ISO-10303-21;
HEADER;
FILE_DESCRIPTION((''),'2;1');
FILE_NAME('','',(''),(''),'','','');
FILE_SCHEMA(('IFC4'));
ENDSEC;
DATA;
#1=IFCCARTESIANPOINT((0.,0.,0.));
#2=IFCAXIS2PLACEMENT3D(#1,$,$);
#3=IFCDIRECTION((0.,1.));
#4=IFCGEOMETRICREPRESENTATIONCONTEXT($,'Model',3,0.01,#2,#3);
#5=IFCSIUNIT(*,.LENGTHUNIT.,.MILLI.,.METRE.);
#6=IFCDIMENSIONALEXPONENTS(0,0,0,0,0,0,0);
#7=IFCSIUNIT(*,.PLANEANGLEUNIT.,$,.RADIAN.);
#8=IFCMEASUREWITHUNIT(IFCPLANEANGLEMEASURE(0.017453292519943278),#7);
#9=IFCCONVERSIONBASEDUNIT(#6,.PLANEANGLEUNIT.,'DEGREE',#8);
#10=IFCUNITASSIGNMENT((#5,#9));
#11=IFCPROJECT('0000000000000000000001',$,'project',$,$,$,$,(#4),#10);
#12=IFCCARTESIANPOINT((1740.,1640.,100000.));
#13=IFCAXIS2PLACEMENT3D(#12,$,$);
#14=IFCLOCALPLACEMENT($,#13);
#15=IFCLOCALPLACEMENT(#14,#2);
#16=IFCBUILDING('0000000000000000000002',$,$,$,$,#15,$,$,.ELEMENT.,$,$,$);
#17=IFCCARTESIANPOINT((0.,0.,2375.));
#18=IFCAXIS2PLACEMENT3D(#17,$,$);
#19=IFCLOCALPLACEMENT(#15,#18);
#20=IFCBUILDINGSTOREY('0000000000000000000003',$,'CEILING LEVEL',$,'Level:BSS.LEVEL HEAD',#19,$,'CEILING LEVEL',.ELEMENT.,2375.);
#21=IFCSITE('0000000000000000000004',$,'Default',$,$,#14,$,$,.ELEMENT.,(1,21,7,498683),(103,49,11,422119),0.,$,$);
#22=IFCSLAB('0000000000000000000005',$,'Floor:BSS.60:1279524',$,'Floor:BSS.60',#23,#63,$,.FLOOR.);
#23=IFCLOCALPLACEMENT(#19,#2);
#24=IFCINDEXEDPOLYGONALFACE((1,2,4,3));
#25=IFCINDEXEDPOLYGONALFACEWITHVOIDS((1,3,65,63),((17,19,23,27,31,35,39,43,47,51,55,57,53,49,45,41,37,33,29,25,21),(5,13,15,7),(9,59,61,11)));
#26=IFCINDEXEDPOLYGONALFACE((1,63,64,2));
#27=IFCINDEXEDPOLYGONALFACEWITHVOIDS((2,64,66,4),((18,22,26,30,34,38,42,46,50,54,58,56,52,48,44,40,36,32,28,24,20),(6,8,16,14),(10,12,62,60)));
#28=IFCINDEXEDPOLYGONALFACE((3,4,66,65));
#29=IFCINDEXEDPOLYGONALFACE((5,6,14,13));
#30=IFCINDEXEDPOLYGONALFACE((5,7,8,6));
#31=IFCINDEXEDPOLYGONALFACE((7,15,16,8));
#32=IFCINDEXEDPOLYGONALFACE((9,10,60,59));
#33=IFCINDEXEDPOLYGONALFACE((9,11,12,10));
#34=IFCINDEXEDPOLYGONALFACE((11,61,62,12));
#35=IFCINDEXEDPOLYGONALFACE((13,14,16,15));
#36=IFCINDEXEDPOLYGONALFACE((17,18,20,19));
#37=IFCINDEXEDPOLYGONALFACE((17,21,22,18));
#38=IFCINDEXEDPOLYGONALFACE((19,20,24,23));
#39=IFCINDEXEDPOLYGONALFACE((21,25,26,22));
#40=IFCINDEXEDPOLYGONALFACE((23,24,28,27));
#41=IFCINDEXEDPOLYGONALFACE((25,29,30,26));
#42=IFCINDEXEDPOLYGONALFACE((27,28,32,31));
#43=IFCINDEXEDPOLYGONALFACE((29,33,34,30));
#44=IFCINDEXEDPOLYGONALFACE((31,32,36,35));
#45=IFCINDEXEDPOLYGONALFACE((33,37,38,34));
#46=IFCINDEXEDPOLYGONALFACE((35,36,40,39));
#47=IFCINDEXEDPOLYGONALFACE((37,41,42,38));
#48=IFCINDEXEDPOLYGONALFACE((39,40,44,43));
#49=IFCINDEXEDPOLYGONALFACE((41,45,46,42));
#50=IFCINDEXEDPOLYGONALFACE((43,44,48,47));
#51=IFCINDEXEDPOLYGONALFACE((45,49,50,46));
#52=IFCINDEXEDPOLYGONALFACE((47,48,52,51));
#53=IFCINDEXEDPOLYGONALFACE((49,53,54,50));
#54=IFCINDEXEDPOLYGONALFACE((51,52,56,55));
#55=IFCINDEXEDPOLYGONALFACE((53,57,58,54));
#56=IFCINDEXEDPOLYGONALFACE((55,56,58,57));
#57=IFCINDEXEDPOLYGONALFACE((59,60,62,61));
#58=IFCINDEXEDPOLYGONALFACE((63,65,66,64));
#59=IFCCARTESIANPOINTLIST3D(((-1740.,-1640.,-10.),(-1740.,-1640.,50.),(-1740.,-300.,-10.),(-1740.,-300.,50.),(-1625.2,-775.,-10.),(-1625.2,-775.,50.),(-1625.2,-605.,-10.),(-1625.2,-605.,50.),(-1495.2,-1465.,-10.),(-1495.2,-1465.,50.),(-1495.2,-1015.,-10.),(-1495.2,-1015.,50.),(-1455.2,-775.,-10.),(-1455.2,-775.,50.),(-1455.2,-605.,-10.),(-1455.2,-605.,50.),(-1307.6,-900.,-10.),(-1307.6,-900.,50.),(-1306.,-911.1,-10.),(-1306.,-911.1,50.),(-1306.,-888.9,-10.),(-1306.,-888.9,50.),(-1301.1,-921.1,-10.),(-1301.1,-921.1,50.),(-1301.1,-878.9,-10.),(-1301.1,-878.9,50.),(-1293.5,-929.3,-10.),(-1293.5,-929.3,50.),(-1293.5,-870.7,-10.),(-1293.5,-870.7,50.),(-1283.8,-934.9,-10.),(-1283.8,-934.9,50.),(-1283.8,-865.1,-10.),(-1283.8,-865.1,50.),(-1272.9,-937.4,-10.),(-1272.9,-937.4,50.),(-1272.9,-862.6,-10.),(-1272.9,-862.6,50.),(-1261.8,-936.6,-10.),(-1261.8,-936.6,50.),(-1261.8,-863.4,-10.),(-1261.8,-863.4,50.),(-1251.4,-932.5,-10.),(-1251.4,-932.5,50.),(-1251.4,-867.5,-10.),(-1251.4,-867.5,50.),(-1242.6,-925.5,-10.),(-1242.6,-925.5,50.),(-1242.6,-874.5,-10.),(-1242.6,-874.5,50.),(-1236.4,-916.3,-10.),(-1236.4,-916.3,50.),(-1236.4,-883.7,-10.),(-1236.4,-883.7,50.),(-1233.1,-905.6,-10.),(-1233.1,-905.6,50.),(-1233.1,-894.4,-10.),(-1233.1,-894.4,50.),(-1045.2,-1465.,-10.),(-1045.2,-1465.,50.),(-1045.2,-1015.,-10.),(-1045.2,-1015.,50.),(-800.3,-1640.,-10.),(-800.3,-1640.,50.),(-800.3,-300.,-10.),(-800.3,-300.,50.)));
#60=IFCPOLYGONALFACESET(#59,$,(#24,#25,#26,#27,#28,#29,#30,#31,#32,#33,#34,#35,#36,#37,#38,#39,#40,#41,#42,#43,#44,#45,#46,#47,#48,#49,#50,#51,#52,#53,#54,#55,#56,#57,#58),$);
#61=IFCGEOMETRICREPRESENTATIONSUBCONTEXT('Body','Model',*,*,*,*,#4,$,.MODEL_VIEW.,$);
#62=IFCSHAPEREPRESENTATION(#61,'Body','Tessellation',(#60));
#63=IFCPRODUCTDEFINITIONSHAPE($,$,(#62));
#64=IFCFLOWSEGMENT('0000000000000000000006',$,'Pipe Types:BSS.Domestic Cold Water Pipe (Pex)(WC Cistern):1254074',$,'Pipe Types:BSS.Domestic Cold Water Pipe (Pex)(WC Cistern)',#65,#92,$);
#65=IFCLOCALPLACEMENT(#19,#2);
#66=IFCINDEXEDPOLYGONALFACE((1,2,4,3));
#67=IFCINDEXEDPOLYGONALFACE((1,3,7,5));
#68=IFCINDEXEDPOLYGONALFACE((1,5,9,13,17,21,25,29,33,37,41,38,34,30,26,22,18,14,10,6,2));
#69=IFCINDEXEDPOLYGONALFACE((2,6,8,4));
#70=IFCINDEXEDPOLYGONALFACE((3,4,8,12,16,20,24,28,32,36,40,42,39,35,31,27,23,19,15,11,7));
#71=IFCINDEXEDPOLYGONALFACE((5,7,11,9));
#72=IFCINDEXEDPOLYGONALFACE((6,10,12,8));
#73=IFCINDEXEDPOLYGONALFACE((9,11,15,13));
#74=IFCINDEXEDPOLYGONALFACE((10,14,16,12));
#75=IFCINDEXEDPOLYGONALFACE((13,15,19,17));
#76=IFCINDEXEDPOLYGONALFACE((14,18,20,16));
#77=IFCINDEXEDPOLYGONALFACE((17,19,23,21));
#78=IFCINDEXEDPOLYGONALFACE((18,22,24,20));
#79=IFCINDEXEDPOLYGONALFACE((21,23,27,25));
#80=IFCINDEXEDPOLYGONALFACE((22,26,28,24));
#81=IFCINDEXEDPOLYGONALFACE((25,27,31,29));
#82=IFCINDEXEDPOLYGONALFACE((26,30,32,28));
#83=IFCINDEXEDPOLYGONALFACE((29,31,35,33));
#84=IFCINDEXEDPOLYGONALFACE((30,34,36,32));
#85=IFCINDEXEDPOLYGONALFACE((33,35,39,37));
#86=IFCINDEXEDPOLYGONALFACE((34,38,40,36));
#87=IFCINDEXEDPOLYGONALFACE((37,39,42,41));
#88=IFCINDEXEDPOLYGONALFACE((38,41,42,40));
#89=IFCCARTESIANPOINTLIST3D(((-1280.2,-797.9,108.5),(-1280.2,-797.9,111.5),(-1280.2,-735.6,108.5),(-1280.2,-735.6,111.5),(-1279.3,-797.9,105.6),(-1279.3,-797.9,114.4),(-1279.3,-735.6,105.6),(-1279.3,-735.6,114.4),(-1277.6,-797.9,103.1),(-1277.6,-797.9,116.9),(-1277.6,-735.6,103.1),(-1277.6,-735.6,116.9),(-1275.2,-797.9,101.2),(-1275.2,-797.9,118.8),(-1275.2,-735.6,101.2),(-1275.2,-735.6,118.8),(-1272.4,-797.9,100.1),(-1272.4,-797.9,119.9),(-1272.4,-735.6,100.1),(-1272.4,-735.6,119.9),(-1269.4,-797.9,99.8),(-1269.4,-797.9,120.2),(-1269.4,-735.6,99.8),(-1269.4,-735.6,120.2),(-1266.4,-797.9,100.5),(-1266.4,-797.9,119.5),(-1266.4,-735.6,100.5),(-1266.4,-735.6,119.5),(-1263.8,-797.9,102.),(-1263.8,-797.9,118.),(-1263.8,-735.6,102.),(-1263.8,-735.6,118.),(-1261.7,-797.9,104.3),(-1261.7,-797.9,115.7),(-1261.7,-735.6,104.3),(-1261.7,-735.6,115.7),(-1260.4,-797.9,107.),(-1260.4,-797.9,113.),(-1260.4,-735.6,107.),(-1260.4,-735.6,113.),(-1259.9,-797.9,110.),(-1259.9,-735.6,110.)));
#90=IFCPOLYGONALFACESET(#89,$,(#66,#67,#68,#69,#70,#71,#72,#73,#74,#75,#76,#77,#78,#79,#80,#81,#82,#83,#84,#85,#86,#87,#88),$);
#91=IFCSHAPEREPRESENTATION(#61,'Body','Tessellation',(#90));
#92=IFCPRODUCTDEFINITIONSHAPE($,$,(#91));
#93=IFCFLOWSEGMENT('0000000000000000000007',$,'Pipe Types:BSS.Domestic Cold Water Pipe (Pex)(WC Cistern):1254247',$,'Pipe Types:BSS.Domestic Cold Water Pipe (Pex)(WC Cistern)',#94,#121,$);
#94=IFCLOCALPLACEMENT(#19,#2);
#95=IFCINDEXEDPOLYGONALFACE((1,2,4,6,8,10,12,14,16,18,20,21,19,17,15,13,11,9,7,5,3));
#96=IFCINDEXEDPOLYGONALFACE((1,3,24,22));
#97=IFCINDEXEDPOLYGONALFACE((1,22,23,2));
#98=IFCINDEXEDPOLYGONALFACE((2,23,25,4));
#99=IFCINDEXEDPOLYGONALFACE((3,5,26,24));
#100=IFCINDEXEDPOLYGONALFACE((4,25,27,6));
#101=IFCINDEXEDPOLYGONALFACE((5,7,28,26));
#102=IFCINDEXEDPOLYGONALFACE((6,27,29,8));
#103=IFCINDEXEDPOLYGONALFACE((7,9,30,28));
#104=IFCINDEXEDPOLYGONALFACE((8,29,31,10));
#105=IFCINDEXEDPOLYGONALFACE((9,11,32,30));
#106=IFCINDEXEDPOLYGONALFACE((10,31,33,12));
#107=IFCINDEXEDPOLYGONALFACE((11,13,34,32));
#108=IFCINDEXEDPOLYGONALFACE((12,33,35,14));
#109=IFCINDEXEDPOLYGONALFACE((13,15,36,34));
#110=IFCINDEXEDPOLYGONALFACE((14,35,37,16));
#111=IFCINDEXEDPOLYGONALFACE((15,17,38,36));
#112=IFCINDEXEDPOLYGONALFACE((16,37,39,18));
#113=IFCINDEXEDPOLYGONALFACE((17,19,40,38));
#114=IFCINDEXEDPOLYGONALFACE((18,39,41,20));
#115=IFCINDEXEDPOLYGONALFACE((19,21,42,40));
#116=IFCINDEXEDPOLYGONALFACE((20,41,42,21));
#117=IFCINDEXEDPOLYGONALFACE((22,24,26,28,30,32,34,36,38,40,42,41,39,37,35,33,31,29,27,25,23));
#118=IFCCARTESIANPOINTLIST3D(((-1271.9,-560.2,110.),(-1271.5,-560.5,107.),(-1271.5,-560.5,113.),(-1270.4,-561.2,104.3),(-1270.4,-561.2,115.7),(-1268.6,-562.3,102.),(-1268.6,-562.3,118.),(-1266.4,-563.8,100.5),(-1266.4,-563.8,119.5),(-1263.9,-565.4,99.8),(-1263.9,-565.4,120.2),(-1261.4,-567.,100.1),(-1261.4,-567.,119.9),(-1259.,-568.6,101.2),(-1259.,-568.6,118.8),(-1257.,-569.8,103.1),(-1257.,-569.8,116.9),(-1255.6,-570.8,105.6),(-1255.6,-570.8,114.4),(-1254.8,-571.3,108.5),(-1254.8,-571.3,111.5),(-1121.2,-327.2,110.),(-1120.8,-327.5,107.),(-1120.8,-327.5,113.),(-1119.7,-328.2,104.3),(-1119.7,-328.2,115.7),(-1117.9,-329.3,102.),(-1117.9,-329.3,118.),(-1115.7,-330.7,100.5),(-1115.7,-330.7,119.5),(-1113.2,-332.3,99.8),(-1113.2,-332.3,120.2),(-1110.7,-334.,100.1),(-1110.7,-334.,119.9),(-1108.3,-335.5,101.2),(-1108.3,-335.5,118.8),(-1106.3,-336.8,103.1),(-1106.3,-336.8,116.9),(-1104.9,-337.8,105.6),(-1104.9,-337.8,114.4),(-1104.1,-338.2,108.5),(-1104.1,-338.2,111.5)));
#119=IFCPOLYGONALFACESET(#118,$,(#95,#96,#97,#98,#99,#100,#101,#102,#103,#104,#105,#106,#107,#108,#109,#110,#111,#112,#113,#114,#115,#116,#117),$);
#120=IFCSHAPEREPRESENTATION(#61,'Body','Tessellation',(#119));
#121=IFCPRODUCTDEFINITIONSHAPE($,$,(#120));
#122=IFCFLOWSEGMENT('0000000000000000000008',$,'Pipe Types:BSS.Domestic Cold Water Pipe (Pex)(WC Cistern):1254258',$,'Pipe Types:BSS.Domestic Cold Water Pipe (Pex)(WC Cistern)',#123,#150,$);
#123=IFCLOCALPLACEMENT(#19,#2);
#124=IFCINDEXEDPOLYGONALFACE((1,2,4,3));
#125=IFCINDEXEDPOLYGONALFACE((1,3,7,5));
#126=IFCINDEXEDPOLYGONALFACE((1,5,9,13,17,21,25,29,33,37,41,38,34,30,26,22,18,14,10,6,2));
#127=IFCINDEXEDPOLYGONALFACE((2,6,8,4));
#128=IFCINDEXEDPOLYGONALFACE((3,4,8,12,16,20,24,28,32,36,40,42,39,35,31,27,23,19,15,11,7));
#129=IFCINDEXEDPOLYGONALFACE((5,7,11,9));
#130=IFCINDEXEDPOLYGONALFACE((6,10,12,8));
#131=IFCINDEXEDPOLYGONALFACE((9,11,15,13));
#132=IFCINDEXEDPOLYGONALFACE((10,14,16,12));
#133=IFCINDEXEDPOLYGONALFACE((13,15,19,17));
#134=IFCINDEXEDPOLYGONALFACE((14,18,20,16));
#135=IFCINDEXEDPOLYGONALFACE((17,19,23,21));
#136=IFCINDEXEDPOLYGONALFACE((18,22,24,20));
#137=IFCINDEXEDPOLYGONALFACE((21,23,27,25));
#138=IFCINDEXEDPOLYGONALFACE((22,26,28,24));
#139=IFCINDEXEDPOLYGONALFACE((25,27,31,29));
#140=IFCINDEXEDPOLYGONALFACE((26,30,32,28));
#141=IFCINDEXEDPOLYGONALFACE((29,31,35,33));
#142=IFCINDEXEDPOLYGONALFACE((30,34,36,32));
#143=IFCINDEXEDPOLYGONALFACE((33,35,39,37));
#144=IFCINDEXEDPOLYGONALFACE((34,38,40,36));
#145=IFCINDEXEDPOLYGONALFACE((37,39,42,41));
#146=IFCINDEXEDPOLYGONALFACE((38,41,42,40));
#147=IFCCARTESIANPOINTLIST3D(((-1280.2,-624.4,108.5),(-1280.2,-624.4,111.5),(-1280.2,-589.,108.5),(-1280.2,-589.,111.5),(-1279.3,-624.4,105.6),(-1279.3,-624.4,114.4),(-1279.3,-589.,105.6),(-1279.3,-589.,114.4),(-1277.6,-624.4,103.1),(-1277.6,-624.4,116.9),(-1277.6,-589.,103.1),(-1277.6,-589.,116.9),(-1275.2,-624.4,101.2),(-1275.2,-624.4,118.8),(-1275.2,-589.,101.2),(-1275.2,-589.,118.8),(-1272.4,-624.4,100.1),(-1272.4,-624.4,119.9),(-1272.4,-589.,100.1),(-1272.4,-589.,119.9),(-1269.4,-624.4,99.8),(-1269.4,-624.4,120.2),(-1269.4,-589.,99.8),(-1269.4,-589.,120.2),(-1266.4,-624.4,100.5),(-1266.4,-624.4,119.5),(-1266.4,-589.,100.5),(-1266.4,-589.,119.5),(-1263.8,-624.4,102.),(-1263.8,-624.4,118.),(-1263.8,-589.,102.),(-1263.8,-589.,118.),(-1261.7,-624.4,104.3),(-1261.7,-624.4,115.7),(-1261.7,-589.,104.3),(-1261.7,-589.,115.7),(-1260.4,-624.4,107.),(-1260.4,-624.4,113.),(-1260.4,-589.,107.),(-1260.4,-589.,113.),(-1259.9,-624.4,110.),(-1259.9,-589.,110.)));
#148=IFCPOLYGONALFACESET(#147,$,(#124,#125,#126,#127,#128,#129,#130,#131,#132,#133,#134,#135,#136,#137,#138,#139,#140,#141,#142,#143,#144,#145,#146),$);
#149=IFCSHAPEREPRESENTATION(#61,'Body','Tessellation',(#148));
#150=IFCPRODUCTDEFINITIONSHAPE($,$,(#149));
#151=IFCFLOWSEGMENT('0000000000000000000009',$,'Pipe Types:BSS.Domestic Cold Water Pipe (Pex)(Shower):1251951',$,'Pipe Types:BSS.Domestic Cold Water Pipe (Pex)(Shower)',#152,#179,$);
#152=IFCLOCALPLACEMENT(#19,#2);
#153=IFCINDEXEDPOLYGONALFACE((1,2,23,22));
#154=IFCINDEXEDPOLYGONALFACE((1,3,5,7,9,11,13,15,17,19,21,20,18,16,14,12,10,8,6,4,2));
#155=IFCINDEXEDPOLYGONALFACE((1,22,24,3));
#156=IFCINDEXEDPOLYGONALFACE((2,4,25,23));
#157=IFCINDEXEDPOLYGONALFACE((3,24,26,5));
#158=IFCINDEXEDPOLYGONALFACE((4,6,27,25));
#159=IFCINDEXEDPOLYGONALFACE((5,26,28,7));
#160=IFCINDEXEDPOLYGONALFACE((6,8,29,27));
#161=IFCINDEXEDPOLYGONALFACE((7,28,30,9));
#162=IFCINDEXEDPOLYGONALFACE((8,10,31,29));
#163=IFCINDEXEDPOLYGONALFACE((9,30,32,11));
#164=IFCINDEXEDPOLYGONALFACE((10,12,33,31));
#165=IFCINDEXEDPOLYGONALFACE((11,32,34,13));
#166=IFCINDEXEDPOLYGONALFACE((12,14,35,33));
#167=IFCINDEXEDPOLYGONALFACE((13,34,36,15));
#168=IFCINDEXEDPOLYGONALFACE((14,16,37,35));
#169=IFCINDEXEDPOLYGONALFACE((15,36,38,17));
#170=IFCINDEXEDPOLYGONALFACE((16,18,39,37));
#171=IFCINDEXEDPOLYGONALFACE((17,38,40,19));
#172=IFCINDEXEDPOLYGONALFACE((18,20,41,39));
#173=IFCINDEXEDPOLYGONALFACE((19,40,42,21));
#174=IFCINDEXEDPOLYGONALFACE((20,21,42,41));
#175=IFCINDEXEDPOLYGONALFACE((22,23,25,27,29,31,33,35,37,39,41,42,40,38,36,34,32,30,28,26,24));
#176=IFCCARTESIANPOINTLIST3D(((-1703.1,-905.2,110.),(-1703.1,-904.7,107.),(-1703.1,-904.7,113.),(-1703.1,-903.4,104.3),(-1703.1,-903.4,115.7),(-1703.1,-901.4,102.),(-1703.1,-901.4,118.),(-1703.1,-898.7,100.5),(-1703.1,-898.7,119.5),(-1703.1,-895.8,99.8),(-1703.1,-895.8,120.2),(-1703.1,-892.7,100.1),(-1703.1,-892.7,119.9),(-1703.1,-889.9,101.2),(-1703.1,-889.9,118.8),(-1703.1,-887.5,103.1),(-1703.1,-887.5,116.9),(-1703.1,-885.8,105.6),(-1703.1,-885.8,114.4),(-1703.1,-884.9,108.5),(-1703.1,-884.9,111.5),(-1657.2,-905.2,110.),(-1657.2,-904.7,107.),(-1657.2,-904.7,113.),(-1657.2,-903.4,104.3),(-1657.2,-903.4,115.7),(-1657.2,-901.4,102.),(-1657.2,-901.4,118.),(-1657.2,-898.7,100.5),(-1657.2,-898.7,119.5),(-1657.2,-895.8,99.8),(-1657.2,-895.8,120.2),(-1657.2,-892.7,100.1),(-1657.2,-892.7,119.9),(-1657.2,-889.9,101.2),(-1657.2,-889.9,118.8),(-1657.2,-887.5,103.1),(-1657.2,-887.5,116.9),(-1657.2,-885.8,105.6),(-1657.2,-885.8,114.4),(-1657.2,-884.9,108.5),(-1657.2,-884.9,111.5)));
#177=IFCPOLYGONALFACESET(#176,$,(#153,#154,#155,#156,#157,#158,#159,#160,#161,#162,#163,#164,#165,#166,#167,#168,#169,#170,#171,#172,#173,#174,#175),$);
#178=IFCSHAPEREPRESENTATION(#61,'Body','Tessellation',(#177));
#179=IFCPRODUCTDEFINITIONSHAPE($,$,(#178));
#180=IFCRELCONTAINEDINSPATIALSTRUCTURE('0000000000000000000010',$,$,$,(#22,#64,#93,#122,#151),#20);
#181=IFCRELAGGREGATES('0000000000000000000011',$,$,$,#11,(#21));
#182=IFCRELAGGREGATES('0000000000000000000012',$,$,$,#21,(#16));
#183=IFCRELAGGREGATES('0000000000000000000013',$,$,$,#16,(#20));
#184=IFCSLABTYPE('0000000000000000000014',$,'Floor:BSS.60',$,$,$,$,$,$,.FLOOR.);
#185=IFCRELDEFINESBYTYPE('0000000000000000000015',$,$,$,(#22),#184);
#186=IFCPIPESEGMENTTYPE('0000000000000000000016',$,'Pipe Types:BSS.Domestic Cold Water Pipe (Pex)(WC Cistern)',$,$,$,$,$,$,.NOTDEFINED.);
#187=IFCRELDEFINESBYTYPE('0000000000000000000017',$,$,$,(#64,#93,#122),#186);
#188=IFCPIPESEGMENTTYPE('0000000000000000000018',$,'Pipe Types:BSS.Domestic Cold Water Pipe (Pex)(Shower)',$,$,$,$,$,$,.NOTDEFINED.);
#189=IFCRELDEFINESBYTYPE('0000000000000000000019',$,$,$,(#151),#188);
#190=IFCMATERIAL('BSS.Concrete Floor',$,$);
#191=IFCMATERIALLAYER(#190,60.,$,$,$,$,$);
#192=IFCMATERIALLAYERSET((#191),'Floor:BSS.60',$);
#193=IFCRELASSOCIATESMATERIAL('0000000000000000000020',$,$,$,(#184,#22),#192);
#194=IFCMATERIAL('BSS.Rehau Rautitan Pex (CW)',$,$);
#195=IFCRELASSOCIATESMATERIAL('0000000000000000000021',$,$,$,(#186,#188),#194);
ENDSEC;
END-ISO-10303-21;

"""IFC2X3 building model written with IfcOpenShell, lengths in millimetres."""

from ifc_helpers import new_model, entity, si_unit, converted_unit, direction, frame, frame_2d, origin, origin_2d_with_axis, place, context, subcontext, project, spatial, rectangle, circle, extrude, material, layer, layer_set, layer_usage, type_object, element, save


model = new_model("IFC2X3")

# Units and contexts
model_context = context("Model", 3, precision=0.01, world=origin(), true_north=direction((0.0, 1.0)))
body_context = subcontext(model_context, "Body", "Model", "MODEL_VIEW")
ifc_project = project(units=[si_unit("LENGTHUNIT", "METRE", prefix="MILLI"), converted_unit("PLANEANGLEUNIT", "DEGREE", entity("IfcPlaneAngleMeasure", 0.017453292519943278), si_unit("PLANEANGLEUNIT", "RADIAN"), dimensions=[0, 0, 0, 0, 0, 0, 0])], contexts=[model_context])

# Site, building, storey
site_placement = place(None, frame((1740.0, 1640.0, 100000.0)))
site = spatial("IfcSite", under=ifc_project, at=site_placement, Name="Default", CompositionType="ELEMENT", RefLatitude=(1, 21, 7, 498683), RefLongitude=(103, 49, 11, 422119), RefElevation=0.0)
building_placement = place(site_placement, origin())
building = spatial("IfcBuilding", under=site, at=building_placement, CompositionType="ELEMENT")
storey_placement = place(building_placement, frame((0.0, 0.0, 2375.0)))
storey = spatial("IfcBuildingStorey", under=building, at=storey_placement, Name="CEILING LEVEL", ObjectType="Level:BSS.LEVEL HEAD", LongName="CEILING LEVEL", CompositionType="ELEMENT", Elevation=2375.0)

# Slab, openings
ifc_material_1 = material(Name="BSS.Concrete Floor")
ifc_layer = layer(ifc_material_1, 60.0)
ifc_layer_set = layer_set([ifc_layer], Name="Floor:BSS.60")
ifc_layer_usage = layer_usage(ifc_layer_set, "AXIS3", "POSITIVE", 0.0)
slab_type = type_object("IfcSlabType", Name="Floor:BSS.60", PredefinedType="FLOOR", material=ifc_layer_set)
slab_placement = place(storey_placement, frame((-1740.0, -1640.0, -10.0)))
slab = element("IfcSlab", 1, at=slab_placement, inside=storey, type_object=slab_type, material=ifc_layer_usage, Name="Floor:BSS.60:1279524", ObjectType="Floor:BSS.60", PredefinedType="FLOOR", context=body_context, shape_type="SweptSolid", body=[
    extrude(rectangle(XDim=1340.0, YDim=939.7, at=frame_2d((0.0, 0.0), x_axis=(0.0, -1.0))), frame((469.9, 670.0, 60.0), z_axis=(0.0, 0.0, -1.0), x_axis=(-1.0, 0.0, 0.0)), (0.0, 0.0, 1.0), 60.0),
])
opening_1_placement = place(slab_placement, origin())
element("IfcOpeningElement", 2, at=opening_1_placement, cuts=slab, ObjectType="Opening", context=body_context, shape_type="SweptSolid", body=[
    extrude(circle(Radius=37.5, at=frame_2d((0.0, 70.0), x_axis=(1.0, 0.0))), frame((469.9, 670.0, 60.0), z_axis=(0.0, 0.0, -1.0), x_axis=(-1.0, 0.0, 0.0)), (0.0, 0.0, 1.0), 60.0),
])
opening_2_placement = place(slab_placement, origin())
element("IfcOpeningElement", 3, at=opening_2_placement, cuts=slab, ObjectType="Opening", context=body_context, shape_type="SweptSolid", body=[
    extrude(rectangle(XDim=170.0, YDim=170.0, at=frame_2d((270.0, 280.0), x_axis=(0.0, -1.0))), frame((469.9, 670.0, 60.0), z_axis=(0.0, 0.0, -1.0), x_axis=(-1.0, 0.0, 0.0)), (0.0, 0.0, 1.0), 60.0),
])
opening_3_placement = place(slab_placement, origin())
element("IfcOpeningElement", 4, at=opening_3_placement, cuts=slab, ObjectType="Opening", context=body_context, shape_type="SweptSolid", body=[
    extrude(rectangle(XDim=450.0, YDim=450.0, at=frame_2d((0.1, -270.0), x_axis=(0.0, -1.0))), frame((469.9, 670.0, 60.0), z_axis=(0.0, 0.0, -1.0), x_axis=(-1.0, 0.0, 0.0)), (0.0, 0.0, 1.0), 60.0),
])

# Flow segments
ifc_material_2 = material(Name="BSS.Rehau Rautitan Pex (CW)")
pipe_segment_type_1 = type_object("IfcPipeSegmentType", Name="Pipe Types:BSS.Domestic Cold Water Pipe (Pex)(WC Cistern)", PredefinedType="NOTDEFINED", material=ifc_material_2)
flow_segment_1_placement = place(storey_placement, origin())
element("IfcFlowSegment", 5, at=flow_segment_1_placement, inside=storey, type_object=pipe_segment_type_1, Name="Pipe Types:BSS.Domestic Cold Water Pipe (Pex)(WC Cistern):1254074", ObjectType="Pipe Types:BSS.Domestic Cold Water Pipe (Pex)(WC Cistern)", context=body_context, shape_type="SweptSolid", body=[
    extrude(circle(Radius=10.2, at=origin_2d_with_axis()), frame((-1270.1, -797.9, 110.0), z_axis=(0.0, 1.0, 0.0), x_axis=(1.0, 0.0, 0.0)), (0.0, 0.0, 1.0), 62.3),
])
flow_segment_2_placement = place(storey_placement, origin())
element("IfcFlowSegment", 6, at=flow_segment_2_placement, inside=storey, type_object=pipe_segment_type_1, Name="Pipe Types:BSS.Domestic Cold Water Pipe (Pex)(WC Cistern):1254247", ObjectType="Pipe Types:BSS.Domestic Cold Water Pipe (Pex)(WC Cistern)", context=body_context, shape_type="SweptSolid", body=[
    extrude(circle(Radius=10.2, at=origin_2d_with_axis()), frame((-1263.3, -565.8, 110.0), z_axis=(0.543056, 0.839696, 0.0), x_axis=(-0.839696, 0.543056, 0.0)), (0.0, 0.0, 1.0), 277.5),
])
flow_segment_3_placement = place(storey_placement, origin())
element("IfcFlowSegment", 7, at=flow_segment_3_placement, inside=storey, type_object=pipe_segment_type_1, Name="Pipe Types:BSS.Domestic Cold Water Pipe (Pex)(WC Cistern):1254258", ObjectType="Pipe Types:BSS.Domestic Cold Water Pipe (Pex)(WC Cistern)", context=body_context, shape_type="SweptSolid", body=[
    extrude(circle(Radius=10.2, at=origin_2d_with_axis()), frame((-1270.1, -624.4, 110.0), z_axis=(0.0, 1.0, 0.0), x_axis=(1.0, 0.0, 0.0)), (0.0, 0.0, 1.0), 35.5),
])
pipe_segment_type_2 = type_object("IfcPipeSegmentType", Name="Pipe Types:BSS.Domestic Cold Water Pipe (Pex)(Shower)", PredefinedType="NOTDEFINED", material=ifc_material_2)
flow_segment_4_placement = place(storey_placement, origin())
element("IfcFlowSegment", 8, at=flow_segment_4_placement, inside=storey, type_object=pipe_segment_type_2, Name="Pipe Types:BSS.Domestic Cold Water Pipe (Pex)(Shower):1251951", ObjectType="Pipe Types:BSS.Domestic Cold Water Pipe (Pex)(Shower)", context=body_context, shape_type="SweptSolid", body=[
    extrude(circle(Radius=10.2, at=origin_2d_with_axis()), frame((-1703.1, -895.0, 110.0), z_axis=(1.0, 0.0, 0.0), x_axis=(0.0, -1.0, 0.0)), (0.0, 0.0, 1.0), 45.9),
])

save(model, "model.ifc")
